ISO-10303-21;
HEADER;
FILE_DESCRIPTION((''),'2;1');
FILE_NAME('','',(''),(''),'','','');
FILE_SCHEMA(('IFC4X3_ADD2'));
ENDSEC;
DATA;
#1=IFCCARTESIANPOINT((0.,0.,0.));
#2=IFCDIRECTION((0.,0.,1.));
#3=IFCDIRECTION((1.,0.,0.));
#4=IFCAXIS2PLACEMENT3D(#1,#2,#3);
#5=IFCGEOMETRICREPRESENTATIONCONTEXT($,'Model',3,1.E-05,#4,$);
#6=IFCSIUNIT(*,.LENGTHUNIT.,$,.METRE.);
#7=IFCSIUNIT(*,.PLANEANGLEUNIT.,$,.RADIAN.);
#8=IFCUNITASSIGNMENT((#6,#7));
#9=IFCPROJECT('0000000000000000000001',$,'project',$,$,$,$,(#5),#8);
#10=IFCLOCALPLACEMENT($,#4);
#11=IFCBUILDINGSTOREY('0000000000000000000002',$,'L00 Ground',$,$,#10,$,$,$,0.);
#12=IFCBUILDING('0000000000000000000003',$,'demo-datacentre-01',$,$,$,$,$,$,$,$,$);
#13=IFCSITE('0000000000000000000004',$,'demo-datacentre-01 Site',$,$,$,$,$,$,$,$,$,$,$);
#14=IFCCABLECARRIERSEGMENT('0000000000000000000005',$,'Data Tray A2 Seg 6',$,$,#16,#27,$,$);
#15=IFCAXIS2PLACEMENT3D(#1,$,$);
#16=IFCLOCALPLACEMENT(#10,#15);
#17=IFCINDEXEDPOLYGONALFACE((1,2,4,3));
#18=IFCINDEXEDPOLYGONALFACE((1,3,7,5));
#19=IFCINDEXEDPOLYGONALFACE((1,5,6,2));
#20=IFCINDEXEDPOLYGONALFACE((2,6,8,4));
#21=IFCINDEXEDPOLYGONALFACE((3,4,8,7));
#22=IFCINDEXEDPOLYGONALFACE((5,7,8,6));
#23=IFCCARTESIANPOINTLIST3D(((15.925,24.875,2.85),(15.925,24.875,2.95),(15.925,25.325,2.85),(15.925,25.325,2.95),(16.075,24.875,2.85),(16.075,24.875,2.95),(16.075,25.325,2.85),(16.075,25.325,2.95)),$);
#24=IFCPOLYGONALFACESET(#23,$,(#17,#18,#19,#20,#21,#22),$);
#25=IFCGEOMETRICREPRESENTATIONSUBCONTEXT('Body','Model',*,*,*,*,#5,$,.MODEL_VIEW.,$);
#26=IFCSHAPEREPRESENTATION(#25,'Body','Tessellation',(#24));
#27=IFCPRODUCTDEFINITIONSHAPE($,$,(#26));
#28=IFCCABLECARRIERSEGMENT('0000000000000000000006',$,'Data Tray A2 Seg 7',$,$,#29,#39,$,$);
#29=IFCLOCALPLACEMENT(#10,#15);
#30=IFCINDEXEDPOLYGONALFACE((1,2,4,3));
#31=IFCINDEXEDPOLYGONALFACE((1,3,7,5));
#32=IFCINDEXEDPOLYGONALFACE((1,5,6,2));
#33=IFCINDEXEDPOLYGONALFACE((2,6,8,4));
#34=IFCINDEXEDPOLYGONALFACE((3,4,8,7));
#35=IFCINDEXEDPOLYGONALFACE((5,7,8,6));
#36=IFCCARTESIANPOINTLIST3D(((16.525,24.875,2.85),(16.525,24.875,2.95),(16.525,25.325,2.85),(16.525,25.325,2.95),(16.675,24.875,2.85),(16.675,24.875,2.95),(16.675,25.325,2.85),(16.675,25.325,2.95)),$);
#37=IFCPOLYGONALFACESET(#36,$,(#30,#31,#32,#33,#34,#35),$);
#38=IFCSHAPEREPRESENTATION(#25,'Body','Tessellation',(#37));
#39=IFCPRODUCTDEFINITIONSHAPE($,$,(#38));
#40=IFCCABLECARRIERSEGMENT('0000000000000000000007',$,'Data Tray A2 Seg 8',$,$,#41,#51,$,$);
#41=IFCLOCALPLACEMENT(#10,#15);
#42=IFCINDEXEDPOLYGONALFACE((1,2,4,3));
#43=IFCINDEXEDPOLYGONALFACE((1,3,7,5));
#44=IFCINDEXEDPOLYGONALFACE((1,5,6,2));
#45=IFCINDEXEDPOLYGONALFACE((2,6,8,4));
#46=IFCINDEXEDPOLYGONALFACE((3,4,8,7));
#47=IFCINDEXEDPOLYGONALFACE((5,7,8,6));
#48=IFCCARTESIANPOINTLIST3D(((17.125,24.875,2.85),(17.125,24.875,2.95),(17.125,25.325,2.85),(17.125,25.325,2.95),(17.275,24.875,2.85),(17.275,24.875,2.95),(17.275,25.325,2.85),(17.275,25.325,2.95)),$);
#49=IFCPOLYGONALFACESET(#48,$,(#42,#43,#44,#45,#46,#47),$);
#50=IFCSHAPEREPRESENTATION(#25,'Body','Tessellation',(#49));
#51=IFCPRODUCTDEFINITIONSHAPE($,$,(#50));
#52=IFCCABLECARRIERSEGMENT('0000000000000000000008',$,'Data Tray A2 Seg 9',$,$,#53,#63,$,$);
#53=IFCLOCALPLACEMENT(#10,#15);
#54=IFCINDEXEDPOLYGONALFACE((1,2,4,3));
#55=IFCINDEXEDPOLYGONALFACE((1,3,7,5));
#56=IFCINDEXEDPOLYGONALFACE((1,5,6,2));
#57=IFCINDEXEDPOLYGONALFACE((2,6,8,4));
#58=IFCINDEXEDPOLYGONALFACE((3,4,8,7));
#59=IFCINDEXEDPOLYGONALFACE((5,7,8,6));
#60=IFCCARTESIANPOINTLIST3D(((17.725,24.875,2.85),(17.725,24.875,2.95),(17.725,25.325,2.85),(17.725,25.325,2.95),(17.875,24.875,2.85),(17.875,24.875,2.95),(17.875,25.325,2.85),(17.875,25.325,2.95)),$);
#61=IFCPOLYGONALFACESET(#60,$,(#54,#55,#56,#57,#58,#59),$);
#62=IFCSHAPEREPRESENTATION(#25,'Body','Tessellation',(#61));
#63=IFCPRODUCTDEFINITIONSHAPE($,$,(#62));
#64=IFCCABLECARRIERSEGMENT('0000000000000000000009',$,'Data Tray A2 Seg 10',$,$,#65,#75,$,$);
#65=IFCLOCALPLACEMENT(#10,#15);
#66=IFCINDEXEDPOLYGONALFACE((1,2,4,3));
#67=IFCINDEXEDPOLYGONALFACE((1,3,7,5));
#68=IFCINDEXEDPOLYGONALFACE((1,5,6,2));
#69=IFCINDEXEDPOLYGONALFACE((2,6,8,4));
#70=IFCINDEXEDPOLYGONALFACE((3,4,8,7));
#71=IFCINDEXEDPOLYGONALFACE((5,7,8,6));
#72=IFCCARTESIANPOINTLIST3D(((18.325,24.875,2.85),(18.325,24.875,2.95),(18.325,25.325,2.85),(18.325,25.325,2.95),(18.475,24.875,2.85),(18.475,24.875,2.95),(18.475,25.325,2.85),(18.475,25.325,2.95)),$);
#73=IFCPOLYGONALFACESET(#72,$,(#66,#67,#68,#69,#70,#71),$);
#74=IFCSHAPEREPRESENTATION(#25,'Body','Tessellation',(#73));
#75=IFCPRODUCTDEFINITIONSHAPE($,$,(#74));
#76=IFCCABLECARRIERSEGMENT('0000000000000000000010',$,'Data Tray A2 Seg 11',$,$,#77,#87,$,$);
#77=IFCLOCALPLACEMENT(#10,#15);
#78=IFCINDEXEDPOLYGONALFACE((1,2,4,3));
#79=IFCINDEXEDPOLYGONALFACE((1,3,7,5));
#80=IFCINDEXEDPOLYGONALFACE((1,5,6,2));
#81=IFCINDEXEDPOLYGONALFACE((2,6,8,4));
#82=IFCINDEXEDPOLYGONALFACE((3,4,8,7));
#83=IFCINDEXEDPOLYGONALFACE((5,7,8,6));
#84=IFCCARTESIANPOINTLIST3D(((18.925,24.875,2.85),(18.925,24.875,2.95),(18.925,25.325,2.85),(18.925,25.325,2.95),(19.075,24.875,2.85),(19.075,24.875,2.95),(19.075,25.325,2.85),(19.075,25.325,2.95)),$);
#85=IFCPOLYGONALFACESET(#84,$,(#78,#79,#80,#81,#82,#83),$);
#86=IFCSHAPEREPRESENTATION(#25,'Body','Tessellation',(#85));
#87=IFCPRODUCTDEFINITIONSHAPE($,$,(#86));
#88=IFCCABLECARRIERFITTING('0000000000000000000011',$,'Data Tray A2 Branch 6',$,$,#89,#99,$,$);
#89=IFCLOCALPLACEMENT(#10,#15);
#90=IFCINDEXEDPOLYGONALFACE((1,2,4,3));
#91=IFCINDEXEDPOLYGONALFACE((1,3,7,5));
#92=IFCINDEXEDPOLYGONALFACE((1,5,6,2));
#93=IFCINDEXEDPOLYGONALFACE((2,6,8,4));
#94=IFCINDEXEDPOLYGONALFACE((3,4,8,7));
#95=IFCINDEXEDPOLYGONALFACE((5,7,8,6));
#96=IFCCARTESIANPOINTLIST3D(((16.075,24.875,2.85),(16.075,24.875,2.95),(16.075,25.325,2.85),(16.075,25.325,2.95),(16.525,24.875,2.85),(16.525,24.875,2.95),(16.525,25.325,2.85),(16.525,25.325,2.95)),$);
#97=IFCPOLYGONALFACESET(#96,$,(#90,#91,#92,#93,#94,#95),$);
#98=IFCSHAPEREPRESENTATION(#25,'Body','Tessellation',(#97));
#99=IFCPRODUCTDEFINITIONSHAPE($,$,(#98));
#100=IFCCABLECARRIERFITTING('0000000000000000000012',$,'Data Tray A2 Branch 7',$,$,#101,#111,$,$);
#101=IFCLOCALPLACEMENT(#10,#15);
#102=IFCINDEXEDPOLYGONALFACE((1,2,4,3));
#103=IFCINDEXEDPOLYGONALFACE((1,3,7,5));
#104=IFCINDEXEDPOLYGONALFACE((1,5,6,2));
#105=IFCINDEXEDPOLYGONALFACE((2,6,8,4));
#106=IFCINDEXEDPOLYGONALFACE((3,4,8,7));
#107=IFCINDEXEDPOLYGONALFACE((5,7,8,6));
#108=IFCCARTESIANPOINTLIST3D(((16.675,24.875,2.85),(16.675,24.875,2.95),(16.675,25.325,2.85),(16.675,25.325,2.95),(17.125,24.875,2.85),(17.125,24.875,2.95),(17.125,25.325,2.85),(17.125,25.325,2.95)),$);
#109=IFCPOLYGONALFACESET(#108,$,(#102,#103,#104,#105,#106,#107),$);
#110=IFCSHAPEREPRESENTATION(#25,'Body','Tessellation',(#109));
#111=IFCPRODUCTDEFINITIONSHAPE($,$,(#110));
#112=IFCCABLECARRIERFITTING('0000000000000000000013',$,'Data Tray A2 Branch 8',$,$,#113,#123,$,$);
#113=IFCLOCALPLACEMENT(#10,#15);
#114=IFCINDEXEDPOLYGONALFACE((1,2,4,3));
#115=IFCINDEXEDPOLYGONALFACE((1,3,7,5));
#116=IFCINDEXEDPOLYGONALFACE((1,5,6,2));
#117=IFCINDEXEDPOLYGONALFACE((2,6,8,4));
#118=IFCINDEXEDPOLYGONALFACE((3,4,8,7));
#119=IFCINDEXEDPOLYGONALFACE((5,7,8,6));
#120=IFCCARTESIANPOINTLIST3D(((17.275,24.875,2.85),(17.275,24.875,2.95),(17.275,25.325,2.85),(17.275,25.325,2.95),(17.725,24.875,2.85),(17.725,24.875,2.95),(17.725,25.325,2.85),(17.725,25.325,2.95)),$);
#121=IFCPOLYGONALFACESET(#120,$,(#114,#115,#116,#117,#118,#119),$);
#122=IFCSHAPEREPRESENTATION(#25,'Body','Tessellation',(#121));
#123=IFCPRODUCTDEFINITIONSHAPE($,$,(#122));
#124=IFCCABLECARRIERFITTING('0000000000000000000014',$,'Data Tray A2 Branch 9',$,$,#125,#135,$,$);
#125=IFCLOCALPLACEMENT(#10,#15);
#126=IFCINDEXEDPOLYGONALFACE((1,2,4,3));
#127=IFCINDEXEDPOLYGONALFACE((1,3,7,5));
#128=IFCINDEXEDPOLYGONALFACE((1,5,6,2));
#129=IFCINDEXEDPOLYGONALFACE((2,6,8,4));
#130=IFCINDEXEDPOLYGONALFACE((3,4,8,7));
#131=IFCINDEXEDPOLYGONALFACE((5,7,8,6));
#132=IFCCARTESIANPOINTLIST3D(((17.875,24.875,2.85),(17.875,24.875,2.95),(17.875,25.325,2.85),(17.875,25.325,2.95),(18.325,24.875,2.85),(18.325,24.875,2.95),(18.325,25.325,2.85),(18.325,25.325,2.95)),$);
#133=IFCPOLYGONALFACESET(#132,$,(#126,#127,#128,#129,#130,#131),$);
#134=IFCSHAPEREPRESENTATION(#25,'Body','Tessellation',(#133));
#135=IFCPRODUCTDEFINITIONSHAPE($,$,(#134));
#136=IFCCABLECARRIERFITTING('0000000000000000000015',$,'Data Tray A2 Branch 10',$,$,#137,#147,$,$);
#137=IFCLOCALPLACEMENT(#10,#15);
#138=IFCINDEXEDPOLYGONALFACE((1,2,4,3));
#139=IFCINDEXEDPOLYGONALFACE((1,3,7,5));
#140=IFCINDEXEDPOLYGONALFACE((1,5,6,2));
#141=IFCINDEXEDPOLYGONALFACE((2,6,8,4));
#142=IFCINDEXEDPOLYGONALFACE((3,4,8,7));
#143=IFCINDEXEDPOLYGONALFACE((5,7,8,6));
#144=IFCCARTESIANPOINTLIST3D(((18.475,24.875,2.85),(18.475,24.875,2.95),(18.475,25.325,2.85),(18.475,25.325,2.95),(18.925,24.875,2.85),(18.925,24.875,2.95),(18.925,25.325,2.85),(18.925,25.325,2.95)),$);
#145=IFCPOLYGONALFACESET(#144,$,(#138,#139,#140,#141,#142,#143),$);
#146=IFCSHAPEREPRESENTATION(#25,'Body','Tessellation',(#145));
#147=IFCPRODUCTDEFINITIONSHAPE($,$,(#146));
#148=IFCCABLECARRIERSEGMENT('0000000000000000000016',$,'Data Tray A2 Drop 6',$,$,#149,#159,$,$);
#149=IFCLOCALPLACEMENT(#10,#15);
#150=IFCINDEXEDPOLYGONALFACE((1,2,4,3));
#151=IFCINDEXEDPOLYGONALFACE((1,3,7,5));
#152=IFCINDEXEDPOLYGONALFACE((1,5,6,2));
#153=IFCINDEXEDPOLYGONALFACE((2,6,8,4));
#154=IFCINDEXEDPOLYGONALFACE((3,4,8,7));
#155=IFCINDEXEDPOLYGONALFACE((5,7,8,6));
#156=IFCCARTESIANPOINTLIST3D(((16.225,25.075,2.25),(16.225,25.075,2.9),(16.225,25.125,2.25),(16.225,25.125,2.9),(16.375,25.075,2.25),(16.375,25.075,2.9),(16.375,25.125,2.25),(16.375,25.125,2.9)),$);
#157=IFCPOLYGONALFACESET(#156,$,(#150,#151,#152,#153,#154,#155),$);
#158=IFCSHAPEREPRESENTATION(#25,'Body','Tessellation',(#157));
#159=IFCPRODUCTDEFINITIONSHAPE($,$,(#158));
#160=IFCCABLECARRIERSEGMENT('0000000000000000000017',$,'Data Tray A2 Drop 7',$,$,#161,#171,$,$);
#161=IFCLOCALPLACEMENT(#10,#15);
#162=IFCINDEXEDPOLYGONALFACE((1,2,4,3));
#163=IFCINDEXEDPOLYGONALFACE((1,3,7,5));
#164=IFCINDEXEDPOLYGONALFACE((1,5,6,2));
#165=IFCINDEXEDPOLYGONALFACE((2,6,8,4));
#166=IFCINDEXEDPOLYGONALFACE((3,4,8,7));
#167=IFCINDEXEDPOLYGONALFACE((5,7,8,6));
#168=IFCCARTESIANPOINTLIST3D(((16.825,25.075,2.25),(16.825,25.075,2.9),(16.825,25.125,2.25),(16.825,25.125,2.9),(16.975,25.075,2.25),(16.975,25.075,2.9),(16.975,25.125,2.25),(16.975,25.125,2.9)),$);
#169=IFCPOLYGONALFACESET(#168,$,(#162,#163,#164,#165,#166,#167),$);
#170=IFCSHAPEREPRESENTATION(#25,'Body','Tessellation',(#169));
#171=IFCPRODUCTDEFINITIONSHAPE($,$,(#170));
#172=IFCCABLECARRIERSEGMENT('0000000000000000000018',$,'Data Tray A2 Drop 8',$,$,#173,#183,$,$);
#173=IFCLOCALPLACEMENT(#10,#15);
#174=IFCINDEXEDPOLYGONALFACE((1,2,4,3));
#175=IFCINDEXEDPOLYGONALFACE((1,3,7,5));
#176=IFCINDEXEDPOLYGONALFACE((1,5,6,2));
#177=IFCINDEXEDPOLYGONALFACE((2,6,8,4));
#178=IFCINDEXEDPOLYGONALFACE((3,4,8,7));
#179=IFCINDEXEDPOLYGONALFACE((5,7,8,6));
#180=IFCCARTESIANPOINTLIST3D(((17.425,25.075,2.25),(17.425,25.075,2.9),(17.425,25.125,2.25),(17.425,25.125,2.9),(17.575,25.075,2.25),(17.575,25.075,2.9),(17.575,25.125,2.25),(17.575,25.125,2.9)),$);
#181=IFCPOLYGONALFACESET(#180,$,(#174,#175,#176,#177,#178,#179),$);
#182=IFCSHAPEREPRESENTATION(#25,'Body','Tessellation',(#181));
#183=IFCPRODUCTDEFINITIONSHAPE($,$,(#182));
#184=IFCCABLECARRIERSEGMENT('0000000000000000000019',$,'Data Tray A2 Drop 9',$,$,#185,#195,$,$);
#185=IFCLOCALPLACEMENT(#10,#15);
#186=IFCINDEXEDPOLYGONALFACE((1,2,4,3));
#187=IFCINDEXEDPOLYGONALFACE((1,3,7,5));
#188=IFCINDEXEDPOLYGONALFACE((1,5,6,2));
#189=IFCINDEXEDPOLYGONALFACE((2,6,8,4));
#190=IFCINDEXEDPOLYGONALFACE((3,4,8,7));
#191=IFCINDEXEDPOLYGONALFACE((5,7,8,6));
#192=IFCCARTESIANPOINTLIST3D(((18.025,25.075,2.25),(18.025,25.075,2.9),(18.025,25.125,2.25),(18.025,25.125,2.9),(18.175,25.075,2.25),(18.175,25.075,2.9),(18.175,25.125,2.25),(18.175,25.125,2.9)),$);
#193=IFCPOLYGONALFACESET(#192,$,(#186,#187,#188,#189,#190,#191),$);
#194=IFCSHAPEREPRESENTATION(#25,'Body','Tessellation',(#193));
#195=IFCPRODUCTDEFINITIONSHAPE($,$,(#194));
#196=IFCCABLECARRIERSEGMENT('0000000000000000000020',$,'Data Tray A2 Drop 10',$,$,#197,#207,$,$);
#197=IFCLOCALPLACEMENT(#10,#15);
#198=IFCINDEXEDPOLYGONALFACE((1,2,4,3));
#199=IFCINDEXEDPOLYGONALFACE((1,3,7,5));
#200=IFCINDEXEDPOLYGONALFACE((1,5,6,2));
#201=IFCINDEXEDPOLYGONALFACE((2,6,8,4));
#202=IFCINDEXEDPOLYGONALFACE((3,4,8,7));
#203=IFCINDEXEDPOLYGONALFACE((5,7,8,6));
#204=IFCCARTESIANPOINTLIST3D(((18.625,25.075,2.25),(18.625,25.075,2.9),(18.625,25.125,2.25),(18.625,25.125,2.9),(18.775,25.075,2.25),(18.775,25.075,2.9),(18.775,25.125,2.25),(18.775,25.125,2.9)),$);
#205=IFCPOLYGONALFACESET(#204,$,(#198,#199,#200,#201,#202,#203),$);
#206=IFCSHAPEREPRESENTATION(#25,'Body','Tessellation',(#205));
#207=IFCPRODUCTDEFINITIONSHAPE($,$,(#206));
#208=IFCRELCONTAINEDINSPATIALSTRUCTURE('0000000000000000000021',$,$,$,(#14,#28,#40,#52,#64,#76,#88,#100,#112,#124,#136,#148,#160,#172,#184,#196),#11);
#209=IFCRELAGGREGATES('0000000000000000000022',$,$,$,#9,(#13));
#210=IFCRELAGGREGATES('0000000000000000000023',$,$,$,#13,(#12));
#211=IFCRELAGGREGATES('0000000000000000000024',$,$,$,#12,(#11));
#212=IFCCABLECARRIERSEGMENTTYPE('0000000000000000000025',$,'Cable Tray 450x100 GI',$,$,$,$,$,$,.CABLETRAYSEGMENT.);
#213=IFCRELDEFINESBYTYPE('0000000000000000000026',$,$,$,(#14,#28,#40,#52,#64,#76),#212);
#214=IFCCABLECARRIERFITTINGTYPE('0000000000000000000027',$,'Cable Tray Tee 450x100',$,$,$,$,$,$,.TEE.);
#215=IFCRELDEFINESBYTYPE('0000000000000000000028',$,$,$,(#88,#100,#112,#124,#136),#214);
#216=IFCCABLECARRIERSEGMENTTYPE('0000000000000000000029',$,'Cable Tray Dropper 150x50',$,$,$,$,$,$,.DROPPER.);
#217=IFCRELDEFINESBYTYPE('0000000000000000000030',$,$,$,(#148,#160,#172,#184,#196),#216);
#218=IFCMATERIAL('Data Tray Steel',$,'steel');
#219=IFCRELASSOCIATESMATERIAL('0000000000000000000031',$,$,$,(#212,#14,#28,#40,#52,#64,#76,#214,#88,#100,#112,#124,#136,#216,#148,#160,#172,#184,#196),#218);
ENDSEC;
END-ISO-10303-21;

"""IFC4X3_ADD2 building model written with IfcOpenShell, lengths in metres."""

from ifc_helpers import new_model, si_unit, frame, origin_with_axes, place, context, subcontext, project, spatial, rectangle, extrude, material, type_object, element, save


model = new_model("IFC4X3_ADD2")

# Units and contexts
model_context = context("Model", 3, precision=1e-05, world=origin_with_axes())
body_context = subcontext(model_context, "Body", "Model", "MODEL_VIEW")
ifc_project = project(units=[si_unit("LENGTHUNIT", "METRE"), si_unit("PLANEANGLEUNIT", "RADIAN")], contexts=[model_context])

# Site, building, storey
site = spatial("IfcSite", under=ifc_project, Name="demo-datacentre-01 Site")
building = spatial("IfcBuilding", under=site, Name="demo-datacentre-01")
storey_placement = place(None, origin_with_axes())
storey = spatial("IfcBuildingStorey", under=building, at=storey_placement, Name="L00 Ground", Elevation=0.0)

# Cable carrier segments
ifc_material_1 = material(Name="Data Tray Steel", Category="steel")
cable_carrier_segment_type_1 = type_object("IfcCableCarrierSegmentType", Name="Cable Tray 450x100 GI", PredefinedType="CABLETRAYSEGMENT", material=ifc_material_1)
cable_carrier_segment_1_placement = place(storey_placement, frame((15.925, 25.1, 2.9), z_axis=(1.0, 0.0, 0.0), x_axis=(0.0, 1.0, 0.0)))
element("IfcCableCarrierSegment", 1, at=cable_carrier_segment_1_placement, inside=storey, type_object=cable_carrier_segment_type_1, material=ifc_material_1, Name="Data Tray A2 Seg 6", context=body_context, shape_type="SweptSolid", body=[
    extrude(rectangle(XDim=0.45, YDim=0.1), origin_with_axes(), (0.0, 0.0, 1.0), 0.15),
])
cable_carrier_segment_2_placement = place(storey_placement, frame((16.525, 25.1, 2.9), z_axis=(1.0, 0.0, 0.0), x_axis=(0.0, 1.0, 0.0)))
element("IfcCableCarrierSegment", 2, at=cable_carrier_segment_2_placement, inside=storey, type_object=cable_carrier_segment_type_1, material=ifc_material_1, Name="Data Tray A2 Seg 7", context=body_context, shape_type="SweptSolid", body=[
    extrude(rectangle(XDim=0.45, YDim=0.1), origin_with_axes(), (0.0, 0.0, 1.0), 0.15),
])
for number, where, z_axis, x_axis, name in (
    (3, (17.125, 25.1, 2.9), (1.0, 0.0, 0.0), (0.0, 1.0, 0.0), "Data Tray A2 Seg 8"),
    (4, (17.725, 25.1, 2.9), (1.0, 0.0, 0.0), (0.0, 1.0, 0.0), "Data Tray A2 Seg 9"),
):
    element("IfcCableCarrierSegment", number, at=place(storey_placement, frame(where, z_axis=z_axis, x_axis=x_axis)), inside=storey, type_object=cable_carrier_segment_type_1, material=ifc_material_1, Name=name, context=body_context, shape_type="SweptSolid", body=[
        extrude(rectangle(XDim=0.45, YDim=0.1), origin_with_axes(), (0.0, 0.0, 1.0), 0.15),
    ])
cable_carrier_segment_3_placement = place(storey_placement, frame((18.325, 25.1, 2.9), z_axis=(1.0, 0.0, 0.0), x_axis=(0.0, 1.0, 0.0)))
element("IfcCableCarrierSegment", 5, at=cable_carrier_segment_3_placement, inside=storey, type_object=cable_carrier_segment_type_1, material=ifc_material_1, Name="Data Tray A2 Seg 10", context=body_context, shape_type="SweptSolid", body=[
    extrude(rectangle(XDim=0.45, YDim=0.1), origin_with_axes(), (0.0, 0.0, 1.0), 0.15),
])
cable_carrier_segment_4_placement = place(storey_placement, frame((18.925, 25.1, 2.9), z_axis=(1.0, 0.0, 0.0), x_axis=(0.0, 1.0, 0.0)))
element("IfcCableCarrierSegment", 6, at=cable_carrier_segment_4_placement, inside=storey, type_object=cable_carrier_segment_type_1, material=ifc_material_1, Name="Data Tray A2 Seg 11", context=body_context, shape_type="SweptSolid", body=[
    extrude(rectangle(XDim=0.45, YDim=0.1), origin_with_axes(), (0.0, 0.0, 1.0), 0.15),
])

# Cable carrier fittings
cable_carrier_fitting_type = type_object("IfcCableCarrierFittingType", Name="Cable Tray Tee 450x100", PredefinedType="TEE", material=ifc_material_1)
for number, where, z_axis, x_axis, name in (
    (7, (16.3, 25.1, 2.85), (0.0, 0.0, 1.0), (1.0, 0.0, 0.0), "Data Tray A2 Branch 6"),
    (8, (16.9, 25.1, 2.85), (0.0, 0.0, 1.0), (1.0, 0.0, 0.0), "Data Tray A2 Branch 7"),
    (9, (17.5, 25.1, 2.85), (0.0, 0.0, 1.0), (1.0, 0.0, 0.0), "Data Tray A2 Branch 8"),
    (10, (18.1, 25.1, 2.85), (0.0, 0.0, 1.0), (1.0, 0.0, 0.0), "Data Tray A2 Branch 9"),
    (11, (18.7, 25.1, 2.85), (0.0, 0.0, 1.0), (1.0, 0.0, 0.0), "Data Tray A2 Branch 10"),
):
    element("IfcCableCarrierFitting", number, at=place(storey_placement, frame(where, z_axis=z_axis, x_axis=x_axis)), inside=storey, type_object=cable_carrier_fitting_type, material=ifc_material_1, Name=name, context=body_context, shape_type="SweptSolid", body=[
        extrude(rectangle(XDim=0.45, YDim=0.45), origin_with_axes(), (0.0, 0.0, 1.0), 0.1),
    ])

# Cable carrier segments
cable_carrier_segment_type_2 = type_object("IfcCableCarrierSegmentType", Name="Cable Tray Dropper 150x50", PredefinedType="DROPPER", material=ifc_material_1)
for number, where, z_axis, x_axis, name in (
    (12, (16.3, 25.1, 2.9), (0.0, 0.0, -1.0), (1.0, 0.0, 0.0), "Data Tray A2 Drop 6"),
    (13, (16.9, 25.1, 2.9), (0.0, 0.0, -1.0), (1.0, 0.0, 0.0), "Data Tray A2 Drop 7"),
    (14, (17.5, 25.1, 2.9), (0.0, 0.0, -1.0), (1.0, 0.0, 0.0), "Data Tray A2 Drop 8"),
    (15, (18.1, 25.1, 2.9), (0.0, 0.0, -1.0), (1.0, 0.0, 0.0), "Data Tray A2 Drop 9"),
    (16, (18.7, 25.1, 2.9), (0.0, 0.0, -1.0), (1.0, 0.0, 0.0), "Data Tray A2 Drop 10"),
):
    element("IfcCableCarrierSegment", number, at=place(storey_placement, frame(where, z_axis=z_axis, x_axis=x_axis)), inside=storey, type_object=cable_carrier_segment_type_2, material=ifc_material_1, Name=name, context=body_context, shape_type="SweptSolid", body=[
        extrude(rectangle(XDim=0.15, YDim=0.05), origin_with_axes(), (0.0, 0.0, 1.0), 0.65),
    ])

save(model, "model.ifc")
